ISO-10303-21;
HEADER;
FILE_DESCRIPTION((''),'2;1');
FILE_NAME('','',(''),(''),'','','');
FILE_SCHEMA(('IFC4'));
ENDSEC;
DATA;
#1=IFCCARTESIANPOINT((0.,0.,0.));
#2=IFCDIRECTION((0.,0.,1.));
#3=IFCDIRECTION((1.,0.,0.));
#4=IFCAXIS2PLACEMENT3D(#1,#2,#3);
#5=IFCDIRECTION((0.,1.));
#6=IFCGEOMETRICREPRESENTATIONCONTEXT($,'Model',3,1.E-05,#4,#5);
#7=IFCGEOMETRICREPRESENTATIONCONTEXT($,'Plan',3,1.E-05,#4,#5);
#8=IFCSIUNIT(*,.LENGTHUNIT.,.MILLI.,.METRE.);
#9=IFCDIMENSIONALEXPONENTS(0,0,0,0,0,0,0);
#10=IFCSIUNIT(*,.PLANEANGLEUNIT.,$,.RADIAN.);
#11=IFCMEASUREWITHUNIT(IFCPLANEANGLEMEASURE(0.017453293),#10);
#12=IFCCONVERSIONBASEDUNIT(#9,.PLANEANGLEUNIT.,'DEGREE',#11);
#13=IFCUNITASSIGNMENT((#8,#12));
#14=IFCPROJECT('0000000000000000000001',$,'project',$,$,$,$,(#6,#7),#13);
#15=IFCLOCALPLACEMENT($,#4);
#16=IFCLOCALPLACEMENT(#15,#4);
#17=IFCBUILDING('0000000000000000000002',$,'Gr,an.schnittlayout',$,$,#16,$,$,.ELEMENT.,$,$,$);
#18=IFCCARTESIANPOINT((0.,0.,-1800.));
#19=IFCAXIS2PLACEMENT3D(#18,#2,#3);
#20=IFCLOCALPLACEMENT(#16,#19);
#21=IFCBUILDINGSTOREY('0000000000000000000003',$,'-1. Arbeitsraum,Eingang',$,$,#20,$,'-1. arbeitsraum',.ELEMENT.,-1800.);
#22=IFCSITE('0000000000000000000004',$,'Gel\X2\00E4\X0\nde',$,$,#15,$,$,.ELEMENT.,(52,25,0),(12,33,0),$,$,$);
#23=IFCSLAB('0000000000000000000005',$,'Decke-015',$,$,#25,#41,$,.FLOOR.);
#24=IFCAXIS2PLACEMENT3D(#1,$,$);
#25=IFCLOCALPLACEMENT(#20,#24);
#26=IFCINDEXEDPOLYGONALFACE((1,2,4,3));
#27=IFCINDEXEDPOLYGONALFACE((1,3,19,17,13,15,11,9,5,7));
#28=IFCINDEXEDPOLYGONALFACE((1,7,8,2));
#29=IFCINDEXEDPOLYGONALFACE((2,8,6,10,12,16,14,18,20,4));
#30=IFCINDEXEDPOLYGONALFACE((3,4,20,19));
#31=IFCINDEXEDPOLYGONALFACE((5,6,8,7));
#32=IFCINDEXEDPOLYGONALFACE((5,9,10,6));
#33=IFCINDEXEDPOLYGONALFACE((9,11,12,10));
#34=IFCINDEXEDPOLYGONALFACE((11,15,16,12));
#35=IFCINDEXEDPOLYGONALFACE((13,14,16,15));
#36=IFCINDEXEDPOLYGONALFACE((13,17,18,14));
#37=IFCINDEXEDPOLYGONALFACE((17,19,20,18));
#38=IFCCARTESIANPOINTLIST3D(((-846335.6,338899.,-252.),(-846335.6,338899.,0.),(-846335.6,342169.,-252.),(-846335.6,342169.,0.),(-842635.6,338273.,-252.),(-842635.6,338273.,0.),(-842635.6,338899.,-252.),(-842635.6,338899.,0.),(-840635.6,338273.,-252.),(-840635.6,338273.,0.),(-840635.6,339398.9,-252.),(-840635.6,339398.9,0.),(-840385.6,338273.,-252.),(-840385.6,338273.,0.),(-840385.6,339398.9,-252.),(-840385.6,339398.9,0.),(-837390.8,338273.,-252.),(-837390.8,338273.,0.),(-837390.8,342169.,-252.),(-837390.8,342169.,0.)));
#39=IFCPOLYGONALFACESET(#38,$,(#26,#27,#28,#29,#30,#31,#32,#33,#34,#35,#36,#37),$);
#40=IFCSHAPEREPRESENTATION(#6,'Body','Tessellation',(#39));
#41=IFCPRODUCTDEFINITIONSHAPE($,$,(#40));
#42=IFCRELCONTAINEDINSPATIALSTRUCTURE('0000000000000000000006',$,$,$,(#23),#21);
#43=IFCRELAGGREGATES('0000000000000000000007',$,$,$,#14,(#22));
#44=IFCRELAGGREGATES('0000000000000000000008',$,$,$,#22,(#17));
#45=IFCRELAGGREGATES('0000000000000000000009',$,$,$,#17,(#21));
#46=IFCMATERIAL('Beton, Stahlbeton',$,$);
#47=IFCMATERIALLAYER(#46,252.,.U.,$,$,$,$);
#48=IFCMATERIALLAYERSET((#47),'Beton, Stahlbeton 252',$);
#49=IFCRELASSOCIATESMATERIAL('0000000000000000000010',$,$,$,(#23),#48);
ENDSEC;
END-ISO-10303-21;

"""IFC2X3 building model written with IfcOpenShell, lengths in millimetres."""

from ifc_helpers import new_model, entity, si_unit, converted_unit, direction, frame, origin_with_axes, place, context, project, spatial, polyline, outline, extrude, material, layer, layer_set, layer_usage, element, save


model = new_model("IFC2X3")

# Units and contexts
model_context = context("Model", 3, precision=1e-05, world=origin_with_axes(), true_north=direction((0.0, 1.0)))
plan_context = context("Plan", 3, precision=1e-05, world=origin_with_axes(), true_north=direction((0.0, 1.0)))
ifc_project = project(units=[si_unit("LENGTHUNIT", "METRE", prefix="MILLI"), converted_unit("PLANEANGLEUNIT", "DEGREE", entity("IfcPlaneAngleMeasure", 0.017453293), si_unit("PLANEANGLEUNIT", "RADIAN"), dimensions=[0, 0, 0, 0, 0, 0, 0])], contexts=[model_context, plan_context])

# Site, building, storey
site_placement = place(None, origin_with_axes())
site = spatial("IfcSite", under=ifc_project, at=site_placement, Name="Gelände", CompositionType="ELEMENT", RefLatitude=(52, 25, 0), RefLongitude=(12, 33, 0))
building_placement = place(site_placement, origin_with_axes())
building = spatial("IfcBuilding", under=site, at=building_placement, Name="Gr,an.schnittlayout", CompositionType="ELEMENT")
storey_placement = place(building_placement, frame((0.0, 0.0, -1800.0), z_axis=(0.0, 0.0, 1.0), x_axis=(1.0, 0.0, 0.0)))
storey = spatial("IfcBuildingStorey", under=building, at=storey_placement, Name="-1. Arbeitsraum,Eingang", LongName="-1. arbeitsraum", CompositionType="ELEMENT", Elevation=-1800.0)

# Slab
ifc_material = material(Name="Beton, Stahlbeton")
ifc_layer = layer(ifc_material, 252.0, ventilated="UNKNOWN")
ifc_layer_set = layer_set([ifc_layer], Name="Beton, Stahlbeton 252")
ifc_layer_usage = layer_usage(ifc_layer_set, "AXIS3", "NEGATIVE", 252.0)
slab_placement = place(storey_placement, frame((-846335.7, 342169.0, -252.0), z_axis=(0.0, 0.0, 1.0), x_axis=(1.0, 0.0, 0.0)))
element("IfcSlab", 1, at=slab_placement, inside=storey, material=ifc_layer_usage, Name="Decke-015", PredefinedType="FLOOR", context=model_context, shape_type="SweptSolid", body=[
    extrude(outline(polyline([(0.0, 0.0), (8944.9, 0.0), (8944.9, -3896.0), (5950.0, -3896.0), (5950.0, -2770.1), (5700.0, -2770.1), (5700.0, -3896.0), (3700.0, -3896.0), (3700.0, -3270.0), (0.0, -3270.0), (0.0, 0.0)])), origin_with_axes(), (0.0, 0.0, 1.0), 252.0),
])

save(model, "model.ifc")
